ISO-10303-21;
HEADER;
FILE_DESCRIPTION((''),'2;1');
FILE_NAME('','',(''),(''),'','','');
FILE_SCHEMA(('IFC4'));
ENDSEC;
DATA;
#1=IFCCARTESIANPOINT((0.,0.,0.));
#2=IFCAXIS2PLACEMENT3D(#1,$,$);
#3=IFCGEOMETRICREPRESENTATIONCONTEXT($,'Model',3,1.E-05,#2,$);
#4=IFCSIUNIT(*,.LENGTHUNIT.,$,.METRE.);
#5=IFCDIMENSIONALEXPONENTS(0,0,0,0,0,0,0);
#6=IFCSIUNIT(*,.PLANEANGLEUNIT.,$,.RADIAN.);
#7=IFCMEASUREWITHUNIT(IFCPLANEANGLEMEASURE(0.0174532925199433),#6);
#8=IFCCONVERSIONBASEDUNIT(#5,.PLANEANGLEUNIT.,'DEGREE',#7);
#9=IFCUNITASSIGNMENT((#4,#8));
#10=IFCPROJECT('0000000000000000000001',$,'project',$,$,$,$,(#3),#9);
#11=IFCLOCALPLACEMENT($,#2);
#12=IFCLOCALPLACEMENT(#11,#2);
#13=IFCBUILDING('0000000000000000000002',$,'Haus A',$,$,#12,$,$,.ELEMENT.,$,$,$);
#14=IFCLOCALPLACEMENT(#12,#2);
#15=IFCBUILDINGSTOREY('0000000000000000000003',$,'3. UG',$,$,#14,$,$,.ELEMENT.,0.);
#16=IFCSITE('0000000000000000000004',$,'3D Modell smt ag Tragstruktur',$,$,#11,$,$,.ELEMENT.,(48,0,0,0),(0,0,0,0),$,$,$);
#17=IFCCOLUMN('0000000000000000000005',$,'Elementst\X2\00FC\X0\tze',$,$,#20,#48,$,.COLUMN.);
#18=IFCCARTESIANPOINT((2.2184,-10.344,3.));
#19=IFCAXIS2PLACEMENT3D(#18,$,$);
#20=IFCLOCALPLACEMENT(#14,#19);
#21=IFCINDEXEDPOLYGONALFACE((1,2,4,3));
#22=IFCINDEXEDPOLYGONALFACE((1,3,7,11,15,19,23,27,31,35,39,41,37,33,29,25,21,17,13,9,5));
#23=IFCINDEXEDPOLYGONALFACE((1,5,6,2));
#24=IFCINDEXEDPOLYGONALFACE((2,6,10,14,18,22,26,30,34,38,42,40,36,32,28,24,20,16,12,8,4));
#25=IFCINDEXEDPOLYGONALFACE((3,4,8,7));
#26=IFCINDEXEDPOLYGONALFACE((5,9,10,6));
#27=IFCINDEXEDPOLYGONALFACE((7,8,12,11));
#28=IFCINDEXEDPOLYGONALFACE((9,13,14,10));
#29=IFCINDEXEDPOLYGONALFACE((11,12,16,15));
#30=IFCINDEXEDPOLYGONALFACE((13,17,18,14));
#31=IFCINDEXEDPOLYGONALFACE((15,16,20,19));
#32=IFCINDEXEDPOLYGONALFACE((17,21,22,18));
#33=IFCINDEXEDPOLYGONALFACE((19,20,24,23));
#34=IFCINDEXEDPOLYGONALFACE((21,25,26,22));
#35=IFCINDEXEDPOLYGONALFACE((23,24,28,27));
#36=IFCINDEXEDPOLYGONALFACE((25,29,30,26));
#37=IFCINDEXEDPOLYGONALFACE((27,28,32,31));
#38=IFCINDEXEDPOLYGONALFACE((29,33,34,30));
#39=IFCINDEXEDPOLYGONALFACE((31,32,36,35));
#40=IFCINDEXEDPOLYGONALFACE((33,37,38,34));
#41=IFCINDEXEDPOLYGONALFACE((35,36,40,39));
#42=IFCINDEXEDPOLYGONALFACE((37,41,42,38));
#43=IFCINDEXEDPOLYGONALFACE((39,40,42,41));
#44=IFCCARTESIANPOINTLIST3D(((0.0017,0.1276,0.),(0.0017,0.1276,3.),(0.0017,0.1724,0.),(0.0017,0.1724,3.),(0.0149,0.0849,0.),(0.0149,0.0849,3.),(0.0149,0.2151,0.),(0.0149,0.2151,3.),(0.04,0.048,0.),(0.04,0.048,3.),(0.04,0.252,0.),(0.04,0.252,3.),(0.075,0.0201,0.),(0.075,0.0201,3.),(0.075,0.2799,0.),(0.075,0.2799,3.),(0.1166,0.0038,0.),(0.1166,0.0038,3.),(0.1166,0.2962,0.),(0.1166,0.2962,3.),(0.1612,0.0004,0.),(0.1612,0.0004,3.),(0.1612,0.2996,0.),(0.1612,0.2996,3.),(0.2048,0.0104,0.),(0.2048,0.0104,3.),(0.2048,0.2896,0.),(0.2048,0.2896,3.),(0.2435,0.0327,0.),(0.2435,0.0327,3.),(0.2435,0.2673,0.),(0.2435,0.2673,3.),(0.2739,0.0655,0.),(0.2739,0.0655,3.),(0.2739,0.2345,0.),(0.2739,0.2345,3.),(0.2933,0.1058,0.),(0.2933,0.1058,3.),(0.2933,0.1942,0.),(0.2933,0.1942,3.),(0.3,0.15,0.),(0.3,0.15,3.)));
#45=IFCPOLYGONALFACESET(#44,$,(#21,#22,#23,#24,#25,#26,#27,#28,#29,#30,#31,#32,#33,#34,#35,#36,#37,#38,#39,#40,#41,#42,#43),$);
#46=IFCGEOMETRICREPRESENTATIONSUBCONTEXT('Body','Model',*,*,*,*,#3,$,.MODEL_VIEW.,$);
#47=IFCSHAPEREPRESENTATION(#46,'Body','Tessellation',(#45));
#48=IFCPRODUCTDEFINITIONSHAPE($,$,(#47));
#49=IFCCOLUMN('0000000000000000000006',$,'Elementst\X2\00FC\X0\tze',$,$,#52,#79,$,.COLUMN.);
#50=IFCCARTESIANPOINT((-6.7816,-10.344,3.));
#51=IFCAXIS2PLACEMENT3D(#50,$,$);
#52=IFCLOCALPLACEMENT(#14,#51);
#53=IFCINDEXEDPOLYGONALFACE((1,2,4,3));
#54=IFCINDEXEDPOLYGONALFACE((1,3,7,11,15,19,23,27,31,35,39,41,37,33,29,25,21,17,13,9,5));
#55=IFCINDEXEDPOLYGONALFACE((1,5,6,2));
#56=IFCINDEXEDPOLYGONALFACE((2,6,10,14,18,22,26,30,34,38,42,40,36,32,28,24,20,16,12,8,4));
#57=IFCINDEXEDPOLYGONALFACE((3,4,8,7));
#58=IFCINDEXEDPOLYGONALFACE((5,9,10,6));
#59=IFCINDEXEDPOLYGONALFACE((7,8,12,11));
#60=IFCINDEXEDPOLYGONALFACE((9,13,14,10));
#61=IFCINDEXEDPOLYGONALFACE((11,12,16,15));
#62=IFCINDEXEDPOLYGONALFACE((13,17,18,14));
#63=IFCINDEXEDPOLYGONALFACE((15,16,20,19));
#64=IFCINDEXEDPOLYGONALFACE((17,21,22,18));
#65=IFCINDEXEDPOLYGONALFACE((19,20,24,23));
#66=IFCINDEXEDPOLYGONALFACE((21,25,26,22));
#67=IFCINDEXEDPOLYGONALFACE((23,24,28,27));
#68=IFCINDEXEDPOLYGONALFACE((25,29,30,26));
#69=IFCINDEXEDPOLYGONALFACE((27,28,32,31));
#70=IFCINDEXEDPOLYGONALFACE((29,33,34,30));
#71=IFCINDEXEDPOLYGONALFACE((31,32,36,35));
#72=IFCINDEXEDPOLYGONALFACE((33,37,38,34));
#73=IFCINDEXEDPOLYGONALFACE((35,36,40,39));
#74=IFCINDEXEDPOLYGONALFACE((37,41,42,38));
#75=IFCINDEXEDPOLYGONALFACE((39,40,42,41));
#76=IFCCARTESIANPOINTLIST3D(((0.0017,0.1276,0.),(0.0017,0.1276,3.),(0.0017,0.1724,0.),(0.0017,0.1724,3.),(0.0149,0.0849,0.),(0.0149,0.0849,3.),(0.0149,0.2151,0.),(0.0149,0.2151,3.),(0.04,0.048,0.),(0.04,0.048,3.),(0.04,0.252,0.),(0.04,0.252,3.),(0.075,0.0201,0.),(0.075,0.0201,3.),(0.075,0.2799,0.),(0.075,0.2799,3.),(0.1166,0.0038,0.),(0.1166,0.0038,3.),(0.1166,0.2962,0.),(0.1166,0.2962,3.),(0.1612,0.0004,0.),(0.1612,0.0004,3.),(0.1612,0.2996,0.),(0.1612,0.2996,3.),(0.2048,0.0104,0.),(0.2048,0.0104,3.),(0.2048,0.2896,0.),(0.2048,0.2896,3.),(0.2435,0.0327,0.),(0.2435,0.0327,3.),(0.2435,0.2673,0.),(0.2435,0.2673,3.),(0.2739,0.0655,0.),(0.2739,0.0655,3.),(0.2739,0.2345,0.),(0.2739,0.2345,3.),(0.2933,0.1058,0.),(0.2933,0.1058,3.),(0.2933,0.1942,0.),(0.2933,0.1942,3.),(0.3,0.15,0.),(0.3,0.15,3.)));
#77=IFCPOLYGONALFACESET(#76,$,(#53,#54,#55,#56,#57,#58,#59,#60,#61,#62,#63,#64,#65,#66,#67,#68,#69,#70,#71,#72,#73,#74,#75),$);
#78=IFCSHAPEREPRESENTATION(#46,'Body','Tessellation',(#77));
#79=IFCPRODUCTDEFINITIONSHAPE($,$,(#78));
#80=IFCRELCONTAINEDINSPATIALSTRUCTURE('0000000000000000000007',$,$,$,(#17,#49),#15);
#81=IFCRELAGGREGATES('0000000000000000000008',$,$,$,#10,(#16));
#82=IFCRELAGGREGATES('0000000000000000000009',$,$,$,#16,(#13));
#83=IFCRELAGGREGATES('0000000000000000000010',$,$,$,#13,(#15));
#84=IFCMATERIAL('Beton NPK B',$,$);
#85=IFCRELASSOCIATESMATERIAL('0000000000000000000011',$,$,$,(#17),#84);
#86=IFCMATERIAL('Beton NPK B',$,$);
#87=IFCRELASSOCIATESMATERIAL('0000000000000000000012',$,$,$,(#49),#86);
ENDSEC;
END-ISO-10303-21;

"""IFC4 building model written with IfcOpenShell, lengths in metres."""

from ifc_helpers import new_model, entity, si_unit, converted_unit, frame, frame_2d, origin, origin_with_axes, place, context, subcontext, project, spatial, circle, extrude, material, element, save


model = new_model("IFC4")

# Units and contexts
model_context = context("Model", 3, precision=1e-05, world=origin())
body_context = subcontext(model_context, "Body", "Model", "MODEL_VIEW")
ifc_project = project(units=[si_unit("LENGTHUNIT", "METRE"), converted_unit("PLANEANGLEUNIT", "DEGREE", entity("IfcPlaneAngleMeasure", 0.0174532925199433), si_unit("PLANEANGLEUNIT", "RADIAN"), dimensions=[0, 0, 0, 0, 0, 0, 0])], contexts=[model_context])

# Site, building, storey
site_placement = place(None, origin())
site = spatial("IfcSite", under=ifc_project, at=site_placement, Name="3D Modell smt ag Tragstruktur", CompositionType="ELEMENT", RefLatitude=(48, 0, 0, 0), RefLongitude=(0, 0, 0, 0))
building_placement = place(site_placement, origin())
building = spatial("IfcBuilding", under=site, at=building_placement, Name="Haus A", CompositionType="ELEMENT")
storey_placement = place(building_placement, origin())
storey = spatial("IfcBuildingStorey", under=building, at=storey_placement, Name="3. UG", CompositionType="ELEMENT", Elevation=0.0)

# Columns
ifc_material_1 = material(Name="Beton NPK B")
column_1_placement = place(storey_placement, frame((2.2184, -10.344, 3.0)))
element("IfcColumn", 1, at=column_1_placement, inside=storey, material=ifc_material_1, Name="Elementstütze", PredefinedType="COLUMN", context=body_context, shape_type="SweptSolid", body=[
    extrude(circle(Radius=0.15, at=frame_2d((0.15, 0.15), x_axis=(1.0, 0.0))), origin_with_axes(), (0.0, 0.0, 1.0), 3.0),
])
ifc_material_2 = material(Name="Beton NPK B")
column_2_placement = place(storey_placement, frame((-6.7816, -10.344, 3.0)))
element("IfcColumn", 2, at=column_2_placement, inside=storey, material=ifc_material_2, Name="Elementstütze", PredefinedType="COLUMN", context=body_context, shape_type="SweptSolid", body=[
    extrude(circle(Radius=0.15, at=frame_2d((0.15, 0.15), x_axis=(1.0, 0.0))), origin_with_axes(), (0.0, 0.0, 1.0), 3.0),
])

save(model, "model.ifc")
